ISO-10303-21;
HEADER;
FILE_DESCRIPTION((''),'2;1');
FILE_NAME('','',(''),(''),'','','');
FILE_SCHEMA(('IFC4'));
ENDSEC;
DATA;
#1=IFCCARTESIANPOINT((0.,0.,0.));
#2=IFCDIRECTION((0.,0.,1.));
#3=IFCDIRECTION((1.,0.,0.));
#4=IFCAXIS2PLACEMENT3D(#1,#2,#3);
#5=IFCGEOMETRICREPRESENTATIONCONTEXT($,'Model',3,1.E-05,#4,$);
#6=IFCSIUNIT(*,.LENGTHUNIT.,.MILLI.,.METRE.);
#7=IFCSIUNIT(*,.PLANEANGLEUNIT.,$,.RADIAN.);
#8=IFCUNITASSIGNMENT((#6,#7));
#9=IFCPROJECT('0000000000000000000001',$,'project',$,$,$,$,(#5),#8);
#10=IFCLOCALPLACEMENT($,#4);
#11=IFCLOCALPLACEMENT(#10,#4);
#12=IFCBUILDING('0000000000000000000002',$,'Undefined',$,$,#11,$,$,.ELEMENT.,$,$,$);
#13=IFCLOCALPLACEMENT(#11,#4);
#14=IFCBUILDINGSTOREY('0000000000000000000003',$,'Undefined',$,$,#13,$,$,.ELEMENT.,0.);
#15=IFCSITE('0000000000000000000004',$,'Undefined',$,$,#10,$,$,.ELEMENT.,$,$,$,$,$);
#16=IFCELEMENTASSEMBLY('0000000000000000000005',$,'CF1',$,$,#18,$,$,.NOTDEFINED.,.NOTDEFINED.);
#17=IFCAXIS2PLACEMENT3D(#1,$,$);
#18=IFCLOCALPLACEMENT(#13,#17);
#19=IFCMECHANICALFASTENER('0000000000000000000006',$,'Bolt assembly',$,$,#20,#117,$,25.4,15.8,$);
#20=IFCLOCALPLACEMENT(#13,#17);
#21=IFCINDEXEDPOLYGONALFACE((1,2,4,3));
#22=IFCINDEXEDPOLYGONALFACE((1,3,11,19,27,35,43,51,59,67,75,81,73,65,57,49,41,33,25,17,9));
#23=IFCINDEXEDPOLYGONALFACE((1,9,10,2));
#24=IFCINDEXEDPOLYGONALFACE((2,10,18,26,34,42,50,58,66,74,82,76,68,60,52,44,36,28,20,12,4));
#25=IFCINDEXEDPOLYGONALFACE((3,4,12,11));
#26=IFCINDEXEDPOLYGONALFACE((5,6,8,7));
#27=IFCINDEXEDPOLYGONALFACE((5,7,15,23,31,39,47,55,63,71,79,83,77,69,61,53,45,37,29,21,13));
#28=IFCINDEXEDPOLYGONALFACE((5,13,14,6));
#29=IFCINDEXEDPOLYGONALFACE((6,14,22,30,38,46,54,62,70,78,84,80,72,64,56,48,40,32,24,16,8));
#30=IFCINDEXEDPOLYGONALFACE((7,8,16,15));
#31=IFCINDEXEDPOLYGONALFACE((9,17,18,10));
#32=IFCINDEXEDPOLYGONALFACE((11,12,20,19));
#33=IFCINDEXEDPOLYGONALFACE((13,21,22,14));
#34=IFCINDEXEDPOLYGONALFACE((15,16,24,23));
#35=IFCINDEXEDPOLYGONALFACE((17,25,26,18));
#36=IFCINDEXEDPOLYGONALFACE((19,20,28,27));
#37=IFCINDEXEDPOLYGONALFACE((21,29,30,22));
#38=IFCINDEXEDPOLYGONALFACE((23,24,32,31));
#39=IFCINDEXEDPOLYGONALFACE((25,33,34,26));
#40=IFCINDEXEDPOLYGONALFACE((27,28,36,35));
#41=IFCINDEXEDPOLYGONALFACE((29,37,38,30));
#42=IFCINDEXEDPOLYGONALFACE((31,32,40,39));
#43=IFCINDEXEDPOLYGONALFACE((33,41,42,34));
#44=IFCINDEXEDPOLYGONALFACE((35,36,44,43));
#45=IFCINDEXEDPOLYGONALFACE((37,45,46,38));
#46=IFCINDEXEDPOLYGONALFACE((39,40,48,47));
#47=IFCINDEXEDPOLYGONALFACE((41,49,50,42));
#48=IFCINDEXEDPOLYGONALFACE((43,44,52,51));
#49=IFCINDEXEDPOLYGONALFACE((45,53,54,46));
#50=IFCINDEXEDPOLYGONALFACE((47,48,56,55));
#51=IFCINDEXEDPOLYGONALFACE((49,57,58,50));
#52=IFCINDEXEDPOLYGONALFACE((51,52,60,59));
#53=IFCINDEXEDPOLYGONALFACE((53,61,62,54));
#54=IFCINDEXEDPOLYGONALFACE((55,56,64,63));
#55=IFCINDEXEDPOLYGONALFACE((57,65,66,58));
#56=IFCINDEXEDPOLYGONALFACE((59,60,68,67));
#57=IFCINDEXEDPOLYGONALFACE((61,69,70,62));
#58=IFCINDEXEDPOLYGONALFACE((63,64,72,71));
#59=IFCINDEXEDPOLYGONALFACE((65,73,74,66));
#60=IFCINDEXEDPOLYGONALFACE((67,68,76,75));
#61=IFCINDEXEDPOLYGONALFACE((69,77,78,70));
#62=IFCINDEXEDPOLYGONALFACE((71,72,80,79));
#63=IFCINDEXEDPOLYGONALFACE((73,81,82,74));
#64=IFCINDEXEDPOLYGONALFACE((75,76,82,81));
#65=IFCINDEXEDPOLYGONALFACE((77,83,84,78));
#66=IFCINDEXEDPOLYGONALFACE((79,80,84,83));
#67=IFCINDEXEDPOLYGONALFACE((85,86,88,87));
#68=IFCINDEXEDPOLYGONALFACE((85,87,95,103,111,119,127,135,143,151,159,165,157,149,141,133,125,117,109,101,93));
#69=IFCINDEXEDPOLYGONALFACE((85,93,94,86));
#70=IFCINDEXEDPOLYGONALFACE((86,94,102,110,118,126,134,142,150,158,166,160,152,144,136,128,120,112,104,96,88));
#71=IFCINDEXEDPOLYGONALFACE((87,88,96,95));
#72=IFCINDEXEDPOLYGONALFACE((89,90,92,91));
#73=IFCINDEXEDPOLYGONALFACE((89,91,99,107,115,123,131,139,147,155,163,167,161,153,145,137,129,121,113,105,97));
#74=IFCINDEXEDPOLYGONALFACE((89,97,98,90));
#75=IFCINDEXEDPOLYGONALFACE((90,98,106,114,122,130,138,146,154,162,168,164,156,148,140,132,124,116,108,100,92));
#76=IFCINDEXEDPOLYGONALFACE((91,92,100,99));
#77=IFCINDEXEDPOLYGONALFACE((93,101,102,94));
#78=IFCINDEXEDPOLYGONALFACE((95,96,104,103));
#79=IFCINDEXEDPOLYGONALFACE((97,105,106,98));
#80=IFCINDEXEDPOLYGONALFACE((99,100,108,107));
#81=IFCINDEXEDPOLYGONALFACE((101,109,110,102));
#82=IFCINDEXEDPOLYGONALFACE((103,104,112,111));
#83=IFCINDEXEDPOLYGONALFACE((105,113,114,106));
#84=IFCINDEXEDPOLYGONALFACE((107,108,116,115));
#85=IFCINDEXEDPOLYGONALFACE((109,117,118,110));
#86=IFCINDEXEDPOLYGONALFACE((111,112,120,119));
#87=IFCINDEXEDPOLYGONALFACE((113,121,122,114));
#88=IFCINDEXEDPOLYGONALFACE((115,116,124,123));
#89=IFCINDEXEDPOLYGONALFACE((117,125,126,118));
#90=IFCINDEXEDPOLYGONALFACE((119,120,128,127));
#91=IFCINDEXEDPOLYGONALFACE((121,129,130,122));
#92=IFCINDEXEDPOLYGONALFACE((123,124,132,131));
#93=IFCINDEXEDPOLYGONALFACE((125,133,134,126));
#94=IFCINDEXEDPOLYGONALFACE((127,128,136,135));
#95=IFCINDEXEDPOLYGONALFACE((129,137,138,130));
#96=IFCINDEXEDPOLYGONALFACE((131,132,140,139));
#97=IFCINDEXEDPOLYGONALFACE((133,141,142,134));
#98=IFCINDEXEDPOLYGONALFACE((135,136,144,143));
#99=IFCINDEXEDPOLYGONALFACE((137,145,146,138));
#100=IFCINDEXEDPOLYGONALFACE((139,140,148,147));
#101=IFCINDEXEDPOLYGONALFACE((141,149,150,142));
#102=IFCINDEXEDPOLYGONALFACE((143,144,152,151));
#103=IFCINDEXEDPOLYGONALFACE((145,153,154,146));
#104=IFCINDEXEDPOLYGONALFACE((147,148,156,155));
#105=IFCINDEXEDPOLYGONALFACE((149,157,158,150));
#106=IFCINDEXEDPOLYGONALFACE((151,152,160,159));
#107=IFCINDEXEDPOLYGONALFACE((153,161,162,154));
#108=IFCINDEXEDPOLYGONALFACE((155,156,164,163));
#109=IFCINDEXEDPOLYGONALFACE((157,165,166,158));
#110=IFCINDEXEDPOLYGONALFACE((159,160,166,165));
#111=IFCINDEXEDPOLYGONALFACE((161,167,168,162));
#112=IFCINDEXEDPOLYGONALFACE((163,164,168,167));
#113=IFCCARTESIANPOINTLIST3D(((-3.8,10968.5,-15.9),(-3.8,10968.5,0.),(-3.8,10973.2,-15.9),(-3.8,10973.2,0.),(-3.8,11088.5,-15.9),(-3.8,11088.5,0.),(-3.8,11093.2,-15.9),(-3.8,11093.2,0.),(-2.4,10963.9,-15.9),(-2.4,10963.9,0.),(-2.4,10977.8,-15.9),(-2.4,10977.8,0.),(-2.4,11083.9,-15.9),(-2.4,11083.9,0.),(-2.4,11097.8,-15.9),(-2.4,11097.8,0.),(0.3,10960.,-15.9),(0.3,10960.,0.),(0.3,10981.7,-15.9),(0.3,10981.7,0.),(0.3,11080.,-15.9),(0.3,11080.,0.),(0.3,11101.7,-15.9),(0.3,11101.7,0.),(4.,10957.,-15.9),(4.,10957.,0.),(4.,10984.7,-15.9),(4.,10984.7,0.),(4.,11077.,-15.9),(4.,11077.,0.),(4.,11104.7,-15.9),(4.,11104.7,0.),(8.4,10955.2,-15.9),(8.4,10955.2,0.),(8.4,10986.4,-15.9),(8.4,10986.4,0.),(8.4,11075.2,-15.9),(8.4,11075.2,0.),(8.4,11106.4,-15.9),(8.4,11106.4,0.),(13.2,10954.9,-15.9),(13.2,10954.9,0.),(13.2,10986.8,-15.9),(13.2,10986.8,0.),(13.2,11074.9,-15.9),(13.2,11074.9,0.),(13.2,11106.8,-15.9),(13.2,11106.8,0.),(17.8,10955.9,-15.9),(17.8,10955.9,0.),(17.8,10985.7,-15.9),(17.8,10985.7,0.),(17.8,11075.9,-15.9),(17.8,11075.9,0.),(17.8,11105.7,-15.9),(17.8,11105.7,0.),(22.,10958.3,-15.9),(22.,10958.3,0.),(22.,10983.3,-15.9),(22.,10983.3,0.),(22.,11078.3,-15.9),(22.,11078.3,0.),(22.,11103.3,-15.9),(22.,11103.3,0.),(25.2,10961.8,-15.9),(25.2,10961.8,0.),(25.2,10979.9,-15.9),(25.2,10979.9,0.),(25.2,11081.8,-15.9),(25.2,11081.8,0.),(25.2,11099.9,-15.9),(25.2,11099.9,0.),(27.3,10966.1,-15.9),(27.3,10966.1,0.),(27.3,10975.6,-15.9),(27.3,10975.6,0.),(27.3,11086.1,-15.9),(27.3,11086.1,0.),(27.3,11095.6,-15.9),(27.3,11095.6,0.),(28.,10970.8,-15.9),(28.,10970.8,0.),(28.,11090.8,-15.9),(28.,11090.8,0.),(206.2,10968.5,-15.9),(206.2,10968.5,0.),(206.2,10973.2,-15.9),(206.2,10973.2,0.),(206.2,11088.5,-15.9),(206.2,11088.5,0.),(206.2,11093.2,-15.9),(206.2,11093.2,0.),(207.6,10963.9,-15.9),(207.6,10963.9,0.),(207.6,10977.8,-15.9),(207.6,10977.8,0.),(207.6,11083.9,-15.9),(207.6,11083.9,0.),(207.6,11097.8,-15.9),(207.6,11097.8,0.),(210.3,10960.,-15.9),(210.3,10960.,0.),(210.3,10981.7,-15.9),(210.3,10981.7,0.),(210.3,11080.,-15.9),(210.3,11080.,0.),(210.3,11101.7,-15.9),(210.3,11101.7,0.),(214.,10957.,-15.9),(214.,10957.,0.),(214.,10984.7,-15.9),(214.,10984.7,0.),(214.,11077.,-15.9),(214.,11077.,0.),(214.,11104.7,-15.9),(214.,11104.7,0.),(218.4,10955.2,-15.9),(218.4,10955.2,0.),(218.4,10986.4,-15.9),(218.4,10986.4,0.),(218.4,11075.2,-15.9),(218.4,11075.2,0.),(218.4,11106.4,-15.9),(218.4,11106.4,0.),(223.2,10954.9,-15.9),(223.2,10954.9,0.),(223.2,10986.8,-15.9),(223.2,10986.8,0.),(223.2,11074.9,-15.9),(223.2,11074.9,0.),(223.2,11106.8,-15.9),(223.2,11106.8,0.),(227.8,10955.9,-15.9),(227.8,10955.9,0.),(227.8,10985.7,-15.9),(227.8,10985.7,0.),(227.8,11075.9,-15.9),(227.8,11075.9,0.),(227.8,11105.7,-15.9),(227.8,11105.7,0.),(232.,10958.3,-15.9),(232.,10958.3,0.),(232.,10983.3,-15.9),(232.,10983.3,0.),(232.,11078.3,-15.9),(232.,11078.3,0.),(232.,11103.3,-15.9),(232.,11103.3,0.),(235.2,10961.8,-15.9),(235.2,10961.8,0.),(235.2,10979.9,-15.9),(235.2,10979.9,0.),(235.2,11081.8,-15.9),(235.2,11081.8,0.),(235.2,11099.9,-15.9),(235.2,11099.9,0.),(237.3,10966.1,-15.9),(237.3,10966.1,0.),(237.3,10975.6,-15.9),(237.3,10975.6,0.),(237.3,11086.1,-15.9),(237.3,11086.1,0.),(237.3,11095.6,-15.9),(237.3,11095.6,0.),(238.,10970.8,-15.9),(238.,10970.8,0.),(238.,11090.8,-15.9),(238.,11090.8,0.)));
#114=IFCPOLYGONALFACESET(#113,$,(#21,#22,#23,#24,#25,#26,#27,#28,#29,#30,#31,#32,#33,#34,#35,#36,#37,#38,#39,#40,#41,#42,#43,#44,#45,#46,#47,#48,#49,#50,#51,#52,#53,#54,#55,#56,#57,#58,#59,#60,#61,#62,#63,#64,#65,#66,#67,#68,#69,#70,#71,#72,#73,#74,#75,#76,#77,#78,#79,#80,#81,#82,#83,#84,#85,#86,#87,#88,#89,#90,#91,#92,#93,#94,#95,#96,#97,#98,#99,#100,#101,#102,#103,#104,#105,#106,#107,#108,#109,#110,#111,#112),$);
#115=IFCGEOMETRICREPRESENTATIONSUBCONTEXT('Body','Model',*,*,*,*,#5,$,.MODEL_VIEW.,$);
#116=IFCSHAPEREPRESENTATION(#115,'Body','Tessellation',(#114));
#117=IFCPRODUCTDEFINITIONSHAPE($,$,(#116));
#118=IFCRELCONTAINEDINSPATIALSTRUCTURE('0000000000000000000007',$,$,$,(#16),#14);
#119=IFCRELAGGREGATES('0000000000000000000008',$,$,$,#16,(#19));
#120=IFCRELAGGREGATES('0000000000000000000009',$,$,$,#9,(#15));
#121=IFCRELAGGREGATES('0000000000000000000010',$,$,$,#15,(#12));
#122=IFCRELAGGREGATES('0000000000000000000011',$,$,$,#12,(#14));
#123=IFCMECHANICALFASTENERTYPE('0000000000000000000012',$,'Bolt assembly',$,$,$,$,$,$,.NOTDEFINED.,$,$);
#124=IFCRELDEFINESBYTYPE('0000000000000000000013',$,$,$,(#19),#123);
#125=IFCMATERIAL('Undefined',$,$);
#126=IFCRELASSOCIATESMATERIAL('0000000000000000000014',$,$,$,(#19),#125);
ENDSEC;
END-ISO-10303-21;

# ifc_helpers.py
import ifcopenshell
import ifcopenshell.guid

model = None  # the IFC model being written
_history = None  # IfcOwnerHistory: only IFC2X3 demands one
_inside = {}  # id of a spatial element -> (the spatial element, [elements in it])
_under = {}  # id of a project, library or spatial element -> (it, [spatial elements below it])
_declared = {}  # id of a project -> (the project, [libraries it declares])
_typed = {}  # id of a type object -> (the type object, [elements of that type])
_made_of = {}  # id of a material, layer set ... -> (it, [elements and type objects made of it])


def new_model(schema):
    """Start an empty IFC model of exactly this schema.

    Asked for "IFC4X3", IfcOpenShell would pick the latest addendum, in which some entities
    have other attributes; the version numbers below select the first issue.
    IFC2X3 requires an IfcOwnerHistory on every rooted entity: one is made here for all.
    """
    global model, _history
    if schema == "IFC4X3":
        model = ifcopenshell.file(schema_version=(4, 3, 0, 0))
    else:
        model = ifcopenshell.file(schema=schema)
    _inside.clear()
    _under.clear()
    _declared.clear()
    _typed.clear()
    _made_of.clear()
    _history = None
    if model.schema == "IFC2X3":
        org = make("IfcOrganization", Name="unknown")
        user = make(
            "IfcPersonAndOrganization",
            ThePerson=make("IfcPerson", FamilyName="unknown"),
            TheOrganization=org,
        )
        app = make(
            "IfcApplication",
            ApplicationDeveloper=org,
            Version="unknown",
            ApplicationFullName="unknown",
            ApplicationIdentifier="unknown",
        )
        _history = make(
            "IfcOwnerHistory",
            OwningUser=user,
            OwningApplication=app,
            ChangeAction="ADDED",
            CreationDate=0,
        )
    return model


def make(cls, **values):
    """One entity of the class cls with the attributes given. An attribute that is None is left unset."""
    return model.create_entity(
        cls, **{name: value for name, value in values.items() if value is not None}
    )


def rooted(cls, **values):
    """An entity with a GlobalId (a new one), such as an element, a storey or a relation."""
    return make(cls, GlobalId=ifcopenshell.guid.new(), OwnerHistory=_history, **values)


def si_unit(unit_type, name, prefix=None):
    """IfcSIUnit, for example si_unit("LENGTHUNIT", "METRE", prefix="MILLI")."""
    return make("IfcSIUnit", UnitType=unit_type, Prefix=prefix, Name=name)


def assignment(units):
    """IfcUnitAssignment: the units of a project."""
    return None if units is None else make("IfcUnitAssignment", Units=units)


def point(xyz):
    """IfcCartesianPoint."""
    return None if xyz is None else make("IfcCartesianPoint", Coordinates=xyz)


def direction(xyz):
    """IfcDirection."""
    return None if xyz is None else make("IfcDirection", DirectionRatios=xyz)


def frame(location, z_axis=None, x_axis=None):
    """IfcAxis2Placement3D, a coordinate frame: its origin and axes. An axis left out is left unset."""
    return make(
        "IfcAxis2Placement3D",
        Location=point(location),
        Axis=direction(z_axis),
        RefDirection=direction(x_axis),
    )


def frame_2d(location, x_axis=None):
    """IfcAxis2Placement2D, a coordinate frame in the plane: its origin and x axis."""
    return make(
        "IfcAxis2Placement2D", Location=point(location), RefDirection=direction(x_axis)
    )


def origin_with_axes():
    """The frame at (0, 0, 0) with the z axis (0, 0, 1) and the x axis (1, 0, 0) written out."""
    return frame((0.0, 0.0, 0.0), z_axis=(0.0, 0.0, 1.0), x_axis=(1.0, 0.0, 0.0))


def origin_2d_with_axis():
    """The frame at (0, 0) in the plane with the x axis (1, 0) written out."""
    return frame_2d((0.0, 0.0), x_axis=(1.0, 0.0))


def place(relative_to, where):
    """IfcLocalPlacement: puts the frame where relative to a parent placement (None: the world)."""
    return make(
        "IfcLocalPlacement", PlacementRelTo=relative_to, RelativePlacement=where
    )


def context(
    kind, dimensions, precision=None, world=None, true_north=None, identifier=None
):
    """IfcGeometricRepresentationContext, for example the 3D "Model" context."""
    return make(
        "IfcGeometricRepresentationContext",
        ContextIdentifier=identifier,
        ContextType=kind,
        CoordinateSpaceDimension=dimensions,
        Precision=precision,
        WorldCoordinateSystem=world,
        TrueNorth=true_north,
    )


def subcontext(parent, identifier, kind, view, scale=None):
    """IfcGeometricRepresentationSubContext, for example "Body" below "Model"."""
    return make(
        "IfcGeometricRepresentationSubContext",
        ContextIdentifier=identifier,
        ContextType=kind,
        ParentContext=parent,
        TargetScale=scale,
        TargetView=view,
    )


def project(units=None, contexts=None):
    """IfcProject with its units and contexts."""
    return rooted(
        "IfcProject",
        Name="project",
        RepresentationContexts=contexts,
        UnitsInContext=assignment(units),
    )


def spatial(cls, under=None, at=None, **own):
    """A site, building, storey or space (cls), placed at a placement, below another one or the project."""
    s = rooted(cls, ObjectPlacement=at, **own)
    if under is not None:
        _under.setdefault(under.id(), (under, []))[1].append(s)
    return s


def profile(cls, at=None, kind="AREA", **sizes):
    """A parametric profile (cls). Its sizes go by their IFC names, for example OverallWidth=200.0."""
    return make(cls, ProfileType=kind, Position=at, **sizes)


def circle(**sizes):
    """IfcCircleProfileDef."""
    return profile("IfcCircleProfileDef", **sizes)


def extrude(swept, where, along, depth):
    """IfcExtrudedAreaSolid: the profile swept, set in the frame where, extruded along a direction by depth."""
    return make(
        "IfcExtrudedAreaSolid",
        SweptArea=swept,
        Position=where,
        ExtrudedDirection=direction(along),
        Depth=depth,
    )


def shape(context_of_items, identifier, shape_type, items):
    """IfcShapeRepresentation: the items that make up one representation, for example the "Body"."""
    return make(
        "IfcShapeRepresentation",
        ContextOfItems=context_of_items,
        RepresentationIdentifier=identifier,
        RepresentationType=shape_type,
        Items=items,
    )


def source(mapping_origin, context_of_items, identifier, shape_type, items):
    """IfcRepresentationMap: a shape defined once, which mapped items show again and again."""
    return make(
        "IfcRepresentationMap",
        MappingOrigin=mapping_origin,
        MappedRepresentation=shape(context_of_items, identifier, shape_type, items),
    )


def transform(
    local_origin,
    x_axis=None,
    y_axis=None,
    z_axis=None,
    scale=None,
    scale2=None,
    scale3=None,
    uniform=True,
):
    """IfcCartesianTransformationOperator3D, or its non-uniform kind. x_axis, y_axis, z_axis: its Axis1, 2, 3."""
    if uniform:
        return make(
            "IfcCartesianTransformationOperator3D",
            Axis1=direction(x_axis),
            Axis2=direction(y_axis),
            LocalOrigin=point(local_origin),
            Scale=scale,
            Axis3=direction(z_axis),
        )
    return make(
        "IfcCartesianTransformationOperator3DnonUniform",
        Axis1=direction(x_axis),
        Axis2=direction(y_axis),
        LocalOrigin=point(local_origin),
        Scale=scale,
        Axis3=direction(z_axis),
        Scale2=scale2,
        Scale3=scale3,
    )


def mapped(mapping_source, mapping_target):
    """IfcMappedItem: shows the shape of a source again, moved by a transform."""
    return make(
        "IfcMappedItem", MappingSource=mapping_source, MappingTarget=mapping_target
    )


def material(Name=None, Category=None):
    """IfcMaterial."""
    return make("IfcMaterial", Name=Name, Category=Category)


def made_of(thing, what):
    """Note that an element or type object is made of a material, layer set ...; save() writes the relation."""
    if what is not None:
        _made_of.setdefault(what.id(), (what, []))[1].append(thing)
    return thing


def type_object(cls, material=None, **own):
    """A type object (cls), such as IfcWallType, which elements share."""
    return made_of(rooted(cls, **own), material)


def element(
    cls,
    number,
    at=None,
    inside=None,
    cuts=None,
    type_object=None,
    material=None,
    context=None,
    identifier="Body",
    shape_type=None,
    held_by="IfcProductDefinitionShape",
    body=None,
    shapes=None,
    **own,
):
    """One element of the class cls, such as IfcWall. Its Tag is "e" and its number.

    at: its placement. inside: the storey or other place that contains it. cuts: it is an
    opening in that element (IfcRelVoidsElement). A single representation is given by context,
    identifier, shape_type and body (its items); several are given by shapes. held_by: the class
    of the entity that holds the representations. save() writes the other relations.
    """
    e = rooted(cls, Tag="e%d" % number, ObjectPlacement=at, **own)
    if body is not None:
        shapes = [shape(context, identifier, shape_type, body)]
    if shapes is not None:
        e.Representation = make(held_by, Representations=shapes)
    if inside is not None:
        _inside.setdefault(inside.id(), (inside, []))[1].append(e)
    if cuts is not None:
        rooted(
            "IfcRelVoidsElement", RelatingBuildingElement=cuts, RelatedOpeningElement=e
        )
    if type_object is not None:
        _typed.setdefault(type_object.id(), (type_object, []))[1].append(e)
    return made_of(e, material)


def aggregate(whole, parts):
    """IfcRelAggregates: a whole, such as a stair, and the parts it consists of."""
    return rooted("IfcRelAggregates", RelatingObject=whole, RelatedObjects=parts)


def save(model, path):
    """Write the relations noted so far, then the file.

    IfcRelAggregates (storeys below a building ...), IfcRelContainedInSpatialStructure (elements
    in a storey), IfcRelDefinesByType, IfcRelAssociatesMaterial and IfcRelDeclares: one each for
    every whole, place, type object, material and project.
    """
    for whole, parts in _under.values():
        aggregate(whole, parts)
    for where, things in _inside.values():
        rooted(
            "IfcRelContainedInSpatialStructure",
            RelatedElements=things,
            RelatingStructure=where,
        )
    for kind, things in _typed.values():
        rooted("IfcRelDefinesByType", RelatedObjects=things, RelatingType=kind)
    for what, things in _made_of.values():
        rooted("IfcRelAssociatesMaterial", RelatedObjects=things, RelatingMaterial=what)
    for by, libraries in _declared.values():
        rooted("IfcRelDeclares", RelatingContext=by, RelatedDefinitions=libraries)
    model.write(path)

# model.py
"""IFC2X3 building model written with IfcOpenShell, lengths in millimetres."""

from ifc_helpers import new_model, si_unit, frame, origin_with_axes, origin_2d_with_axis, place, context, subcontext, project, spatial, circle, extrude, source, transform, mapped, material, type_object, element, aggregate, save


model = new_model("IFC2X3")

# Units and contexts
model_context = context("Model", 3, precision=1e-05, world=origin_with_axes())
body_context = subcontext(model_context, "Body", "Model", "MODEL_VIEW")
ifc_project = project(units=[si_unit("LENGTHUNIT", "METRE", prefix="MILLI"), si_unit("PLANEANGLEUNIT", "RADIAN")], contexts=[model_context])

# Site, building, storey
site_placement = place(None, origin_with_axes())
site = spatial("IfcSite", under=ifc_project, at=site_placement, Name="Undefined", CompositionType="ELEMENT")
building_placement = place(site_placement, origin_with_axes())
building = spatial("IfcBuilding", under=site, at=building_placement, Name="Undefined", CompositionType="ELEMENT")
storey_placement = place(building_placement, origin_with_axes())
storey = spatial("IfcBuildingStorey", under=building, at=storey_placement, Name="Undefined", CompositionType="ELEMENT", Elevation=0.0)

# Element assembly
assembly_1_placement = place(storey_placement, origin_with_axes())
assembly_1 = element("IfcElementAssembly", 1, at=assembly_1_placement, inside=storey, Name="CF1", AssemblyPlace="NOTDEFINED", PredefinedType="NOTDEFINED")

# Shared definitions
ifc_material_1 = material(Name="Undefined")
mechanical_fastener_type = type_object("IfcMechanicalFastenerType", Name="Bolt assembly")

# Mechanical fastener
shared_shape_1 = source(origin_with_axes(), body_context, "Body", "SweptSolid", [
    extrude(circle(Radius=16.0, at=origin_2d_with_axis()), frame((0.0, 0.0, 0.0), z_axis=(0.0, 1.0, 0.0), x_axis=(1.0, 0.0, 0.0)), (0.0, 0.0, 1.0), 15.9),
])
mechanical_fastener_1_placement = place(assembly_1_placement, frame((12.0, 11030.8, 0.0), z_axis=(0.0, 1.0, 0.0), x_axis=(1.0, 0.0, 0.0)))
mechanical_fastener_1 = element("IfcMechanicalFastener", 2, at=mechanical_fastener_1_placement, type_object=mechanical_fastener_type, material=ifc_material_1, Name="Bolt assembly", NominalDiameter=25.4, NominalLength=15.8, context=body_context, shape_type="MappedRepresentation", body=[
    mapped(shared_shape_1, transform((0.0, 0.0, -60.0))),
    mapped(shared_shape_1, transform((210.0, 0.0, -60.0))),
    mapped(shared_shape_1, transform((0.0, 0.0, 60.0))),
    mapped(shared_shape_1, transform((210.0, 0.0, 60.0))),
])
aggregate(assembly_1, [mechanical_fastener_1])

save(model, "model.ifc")
